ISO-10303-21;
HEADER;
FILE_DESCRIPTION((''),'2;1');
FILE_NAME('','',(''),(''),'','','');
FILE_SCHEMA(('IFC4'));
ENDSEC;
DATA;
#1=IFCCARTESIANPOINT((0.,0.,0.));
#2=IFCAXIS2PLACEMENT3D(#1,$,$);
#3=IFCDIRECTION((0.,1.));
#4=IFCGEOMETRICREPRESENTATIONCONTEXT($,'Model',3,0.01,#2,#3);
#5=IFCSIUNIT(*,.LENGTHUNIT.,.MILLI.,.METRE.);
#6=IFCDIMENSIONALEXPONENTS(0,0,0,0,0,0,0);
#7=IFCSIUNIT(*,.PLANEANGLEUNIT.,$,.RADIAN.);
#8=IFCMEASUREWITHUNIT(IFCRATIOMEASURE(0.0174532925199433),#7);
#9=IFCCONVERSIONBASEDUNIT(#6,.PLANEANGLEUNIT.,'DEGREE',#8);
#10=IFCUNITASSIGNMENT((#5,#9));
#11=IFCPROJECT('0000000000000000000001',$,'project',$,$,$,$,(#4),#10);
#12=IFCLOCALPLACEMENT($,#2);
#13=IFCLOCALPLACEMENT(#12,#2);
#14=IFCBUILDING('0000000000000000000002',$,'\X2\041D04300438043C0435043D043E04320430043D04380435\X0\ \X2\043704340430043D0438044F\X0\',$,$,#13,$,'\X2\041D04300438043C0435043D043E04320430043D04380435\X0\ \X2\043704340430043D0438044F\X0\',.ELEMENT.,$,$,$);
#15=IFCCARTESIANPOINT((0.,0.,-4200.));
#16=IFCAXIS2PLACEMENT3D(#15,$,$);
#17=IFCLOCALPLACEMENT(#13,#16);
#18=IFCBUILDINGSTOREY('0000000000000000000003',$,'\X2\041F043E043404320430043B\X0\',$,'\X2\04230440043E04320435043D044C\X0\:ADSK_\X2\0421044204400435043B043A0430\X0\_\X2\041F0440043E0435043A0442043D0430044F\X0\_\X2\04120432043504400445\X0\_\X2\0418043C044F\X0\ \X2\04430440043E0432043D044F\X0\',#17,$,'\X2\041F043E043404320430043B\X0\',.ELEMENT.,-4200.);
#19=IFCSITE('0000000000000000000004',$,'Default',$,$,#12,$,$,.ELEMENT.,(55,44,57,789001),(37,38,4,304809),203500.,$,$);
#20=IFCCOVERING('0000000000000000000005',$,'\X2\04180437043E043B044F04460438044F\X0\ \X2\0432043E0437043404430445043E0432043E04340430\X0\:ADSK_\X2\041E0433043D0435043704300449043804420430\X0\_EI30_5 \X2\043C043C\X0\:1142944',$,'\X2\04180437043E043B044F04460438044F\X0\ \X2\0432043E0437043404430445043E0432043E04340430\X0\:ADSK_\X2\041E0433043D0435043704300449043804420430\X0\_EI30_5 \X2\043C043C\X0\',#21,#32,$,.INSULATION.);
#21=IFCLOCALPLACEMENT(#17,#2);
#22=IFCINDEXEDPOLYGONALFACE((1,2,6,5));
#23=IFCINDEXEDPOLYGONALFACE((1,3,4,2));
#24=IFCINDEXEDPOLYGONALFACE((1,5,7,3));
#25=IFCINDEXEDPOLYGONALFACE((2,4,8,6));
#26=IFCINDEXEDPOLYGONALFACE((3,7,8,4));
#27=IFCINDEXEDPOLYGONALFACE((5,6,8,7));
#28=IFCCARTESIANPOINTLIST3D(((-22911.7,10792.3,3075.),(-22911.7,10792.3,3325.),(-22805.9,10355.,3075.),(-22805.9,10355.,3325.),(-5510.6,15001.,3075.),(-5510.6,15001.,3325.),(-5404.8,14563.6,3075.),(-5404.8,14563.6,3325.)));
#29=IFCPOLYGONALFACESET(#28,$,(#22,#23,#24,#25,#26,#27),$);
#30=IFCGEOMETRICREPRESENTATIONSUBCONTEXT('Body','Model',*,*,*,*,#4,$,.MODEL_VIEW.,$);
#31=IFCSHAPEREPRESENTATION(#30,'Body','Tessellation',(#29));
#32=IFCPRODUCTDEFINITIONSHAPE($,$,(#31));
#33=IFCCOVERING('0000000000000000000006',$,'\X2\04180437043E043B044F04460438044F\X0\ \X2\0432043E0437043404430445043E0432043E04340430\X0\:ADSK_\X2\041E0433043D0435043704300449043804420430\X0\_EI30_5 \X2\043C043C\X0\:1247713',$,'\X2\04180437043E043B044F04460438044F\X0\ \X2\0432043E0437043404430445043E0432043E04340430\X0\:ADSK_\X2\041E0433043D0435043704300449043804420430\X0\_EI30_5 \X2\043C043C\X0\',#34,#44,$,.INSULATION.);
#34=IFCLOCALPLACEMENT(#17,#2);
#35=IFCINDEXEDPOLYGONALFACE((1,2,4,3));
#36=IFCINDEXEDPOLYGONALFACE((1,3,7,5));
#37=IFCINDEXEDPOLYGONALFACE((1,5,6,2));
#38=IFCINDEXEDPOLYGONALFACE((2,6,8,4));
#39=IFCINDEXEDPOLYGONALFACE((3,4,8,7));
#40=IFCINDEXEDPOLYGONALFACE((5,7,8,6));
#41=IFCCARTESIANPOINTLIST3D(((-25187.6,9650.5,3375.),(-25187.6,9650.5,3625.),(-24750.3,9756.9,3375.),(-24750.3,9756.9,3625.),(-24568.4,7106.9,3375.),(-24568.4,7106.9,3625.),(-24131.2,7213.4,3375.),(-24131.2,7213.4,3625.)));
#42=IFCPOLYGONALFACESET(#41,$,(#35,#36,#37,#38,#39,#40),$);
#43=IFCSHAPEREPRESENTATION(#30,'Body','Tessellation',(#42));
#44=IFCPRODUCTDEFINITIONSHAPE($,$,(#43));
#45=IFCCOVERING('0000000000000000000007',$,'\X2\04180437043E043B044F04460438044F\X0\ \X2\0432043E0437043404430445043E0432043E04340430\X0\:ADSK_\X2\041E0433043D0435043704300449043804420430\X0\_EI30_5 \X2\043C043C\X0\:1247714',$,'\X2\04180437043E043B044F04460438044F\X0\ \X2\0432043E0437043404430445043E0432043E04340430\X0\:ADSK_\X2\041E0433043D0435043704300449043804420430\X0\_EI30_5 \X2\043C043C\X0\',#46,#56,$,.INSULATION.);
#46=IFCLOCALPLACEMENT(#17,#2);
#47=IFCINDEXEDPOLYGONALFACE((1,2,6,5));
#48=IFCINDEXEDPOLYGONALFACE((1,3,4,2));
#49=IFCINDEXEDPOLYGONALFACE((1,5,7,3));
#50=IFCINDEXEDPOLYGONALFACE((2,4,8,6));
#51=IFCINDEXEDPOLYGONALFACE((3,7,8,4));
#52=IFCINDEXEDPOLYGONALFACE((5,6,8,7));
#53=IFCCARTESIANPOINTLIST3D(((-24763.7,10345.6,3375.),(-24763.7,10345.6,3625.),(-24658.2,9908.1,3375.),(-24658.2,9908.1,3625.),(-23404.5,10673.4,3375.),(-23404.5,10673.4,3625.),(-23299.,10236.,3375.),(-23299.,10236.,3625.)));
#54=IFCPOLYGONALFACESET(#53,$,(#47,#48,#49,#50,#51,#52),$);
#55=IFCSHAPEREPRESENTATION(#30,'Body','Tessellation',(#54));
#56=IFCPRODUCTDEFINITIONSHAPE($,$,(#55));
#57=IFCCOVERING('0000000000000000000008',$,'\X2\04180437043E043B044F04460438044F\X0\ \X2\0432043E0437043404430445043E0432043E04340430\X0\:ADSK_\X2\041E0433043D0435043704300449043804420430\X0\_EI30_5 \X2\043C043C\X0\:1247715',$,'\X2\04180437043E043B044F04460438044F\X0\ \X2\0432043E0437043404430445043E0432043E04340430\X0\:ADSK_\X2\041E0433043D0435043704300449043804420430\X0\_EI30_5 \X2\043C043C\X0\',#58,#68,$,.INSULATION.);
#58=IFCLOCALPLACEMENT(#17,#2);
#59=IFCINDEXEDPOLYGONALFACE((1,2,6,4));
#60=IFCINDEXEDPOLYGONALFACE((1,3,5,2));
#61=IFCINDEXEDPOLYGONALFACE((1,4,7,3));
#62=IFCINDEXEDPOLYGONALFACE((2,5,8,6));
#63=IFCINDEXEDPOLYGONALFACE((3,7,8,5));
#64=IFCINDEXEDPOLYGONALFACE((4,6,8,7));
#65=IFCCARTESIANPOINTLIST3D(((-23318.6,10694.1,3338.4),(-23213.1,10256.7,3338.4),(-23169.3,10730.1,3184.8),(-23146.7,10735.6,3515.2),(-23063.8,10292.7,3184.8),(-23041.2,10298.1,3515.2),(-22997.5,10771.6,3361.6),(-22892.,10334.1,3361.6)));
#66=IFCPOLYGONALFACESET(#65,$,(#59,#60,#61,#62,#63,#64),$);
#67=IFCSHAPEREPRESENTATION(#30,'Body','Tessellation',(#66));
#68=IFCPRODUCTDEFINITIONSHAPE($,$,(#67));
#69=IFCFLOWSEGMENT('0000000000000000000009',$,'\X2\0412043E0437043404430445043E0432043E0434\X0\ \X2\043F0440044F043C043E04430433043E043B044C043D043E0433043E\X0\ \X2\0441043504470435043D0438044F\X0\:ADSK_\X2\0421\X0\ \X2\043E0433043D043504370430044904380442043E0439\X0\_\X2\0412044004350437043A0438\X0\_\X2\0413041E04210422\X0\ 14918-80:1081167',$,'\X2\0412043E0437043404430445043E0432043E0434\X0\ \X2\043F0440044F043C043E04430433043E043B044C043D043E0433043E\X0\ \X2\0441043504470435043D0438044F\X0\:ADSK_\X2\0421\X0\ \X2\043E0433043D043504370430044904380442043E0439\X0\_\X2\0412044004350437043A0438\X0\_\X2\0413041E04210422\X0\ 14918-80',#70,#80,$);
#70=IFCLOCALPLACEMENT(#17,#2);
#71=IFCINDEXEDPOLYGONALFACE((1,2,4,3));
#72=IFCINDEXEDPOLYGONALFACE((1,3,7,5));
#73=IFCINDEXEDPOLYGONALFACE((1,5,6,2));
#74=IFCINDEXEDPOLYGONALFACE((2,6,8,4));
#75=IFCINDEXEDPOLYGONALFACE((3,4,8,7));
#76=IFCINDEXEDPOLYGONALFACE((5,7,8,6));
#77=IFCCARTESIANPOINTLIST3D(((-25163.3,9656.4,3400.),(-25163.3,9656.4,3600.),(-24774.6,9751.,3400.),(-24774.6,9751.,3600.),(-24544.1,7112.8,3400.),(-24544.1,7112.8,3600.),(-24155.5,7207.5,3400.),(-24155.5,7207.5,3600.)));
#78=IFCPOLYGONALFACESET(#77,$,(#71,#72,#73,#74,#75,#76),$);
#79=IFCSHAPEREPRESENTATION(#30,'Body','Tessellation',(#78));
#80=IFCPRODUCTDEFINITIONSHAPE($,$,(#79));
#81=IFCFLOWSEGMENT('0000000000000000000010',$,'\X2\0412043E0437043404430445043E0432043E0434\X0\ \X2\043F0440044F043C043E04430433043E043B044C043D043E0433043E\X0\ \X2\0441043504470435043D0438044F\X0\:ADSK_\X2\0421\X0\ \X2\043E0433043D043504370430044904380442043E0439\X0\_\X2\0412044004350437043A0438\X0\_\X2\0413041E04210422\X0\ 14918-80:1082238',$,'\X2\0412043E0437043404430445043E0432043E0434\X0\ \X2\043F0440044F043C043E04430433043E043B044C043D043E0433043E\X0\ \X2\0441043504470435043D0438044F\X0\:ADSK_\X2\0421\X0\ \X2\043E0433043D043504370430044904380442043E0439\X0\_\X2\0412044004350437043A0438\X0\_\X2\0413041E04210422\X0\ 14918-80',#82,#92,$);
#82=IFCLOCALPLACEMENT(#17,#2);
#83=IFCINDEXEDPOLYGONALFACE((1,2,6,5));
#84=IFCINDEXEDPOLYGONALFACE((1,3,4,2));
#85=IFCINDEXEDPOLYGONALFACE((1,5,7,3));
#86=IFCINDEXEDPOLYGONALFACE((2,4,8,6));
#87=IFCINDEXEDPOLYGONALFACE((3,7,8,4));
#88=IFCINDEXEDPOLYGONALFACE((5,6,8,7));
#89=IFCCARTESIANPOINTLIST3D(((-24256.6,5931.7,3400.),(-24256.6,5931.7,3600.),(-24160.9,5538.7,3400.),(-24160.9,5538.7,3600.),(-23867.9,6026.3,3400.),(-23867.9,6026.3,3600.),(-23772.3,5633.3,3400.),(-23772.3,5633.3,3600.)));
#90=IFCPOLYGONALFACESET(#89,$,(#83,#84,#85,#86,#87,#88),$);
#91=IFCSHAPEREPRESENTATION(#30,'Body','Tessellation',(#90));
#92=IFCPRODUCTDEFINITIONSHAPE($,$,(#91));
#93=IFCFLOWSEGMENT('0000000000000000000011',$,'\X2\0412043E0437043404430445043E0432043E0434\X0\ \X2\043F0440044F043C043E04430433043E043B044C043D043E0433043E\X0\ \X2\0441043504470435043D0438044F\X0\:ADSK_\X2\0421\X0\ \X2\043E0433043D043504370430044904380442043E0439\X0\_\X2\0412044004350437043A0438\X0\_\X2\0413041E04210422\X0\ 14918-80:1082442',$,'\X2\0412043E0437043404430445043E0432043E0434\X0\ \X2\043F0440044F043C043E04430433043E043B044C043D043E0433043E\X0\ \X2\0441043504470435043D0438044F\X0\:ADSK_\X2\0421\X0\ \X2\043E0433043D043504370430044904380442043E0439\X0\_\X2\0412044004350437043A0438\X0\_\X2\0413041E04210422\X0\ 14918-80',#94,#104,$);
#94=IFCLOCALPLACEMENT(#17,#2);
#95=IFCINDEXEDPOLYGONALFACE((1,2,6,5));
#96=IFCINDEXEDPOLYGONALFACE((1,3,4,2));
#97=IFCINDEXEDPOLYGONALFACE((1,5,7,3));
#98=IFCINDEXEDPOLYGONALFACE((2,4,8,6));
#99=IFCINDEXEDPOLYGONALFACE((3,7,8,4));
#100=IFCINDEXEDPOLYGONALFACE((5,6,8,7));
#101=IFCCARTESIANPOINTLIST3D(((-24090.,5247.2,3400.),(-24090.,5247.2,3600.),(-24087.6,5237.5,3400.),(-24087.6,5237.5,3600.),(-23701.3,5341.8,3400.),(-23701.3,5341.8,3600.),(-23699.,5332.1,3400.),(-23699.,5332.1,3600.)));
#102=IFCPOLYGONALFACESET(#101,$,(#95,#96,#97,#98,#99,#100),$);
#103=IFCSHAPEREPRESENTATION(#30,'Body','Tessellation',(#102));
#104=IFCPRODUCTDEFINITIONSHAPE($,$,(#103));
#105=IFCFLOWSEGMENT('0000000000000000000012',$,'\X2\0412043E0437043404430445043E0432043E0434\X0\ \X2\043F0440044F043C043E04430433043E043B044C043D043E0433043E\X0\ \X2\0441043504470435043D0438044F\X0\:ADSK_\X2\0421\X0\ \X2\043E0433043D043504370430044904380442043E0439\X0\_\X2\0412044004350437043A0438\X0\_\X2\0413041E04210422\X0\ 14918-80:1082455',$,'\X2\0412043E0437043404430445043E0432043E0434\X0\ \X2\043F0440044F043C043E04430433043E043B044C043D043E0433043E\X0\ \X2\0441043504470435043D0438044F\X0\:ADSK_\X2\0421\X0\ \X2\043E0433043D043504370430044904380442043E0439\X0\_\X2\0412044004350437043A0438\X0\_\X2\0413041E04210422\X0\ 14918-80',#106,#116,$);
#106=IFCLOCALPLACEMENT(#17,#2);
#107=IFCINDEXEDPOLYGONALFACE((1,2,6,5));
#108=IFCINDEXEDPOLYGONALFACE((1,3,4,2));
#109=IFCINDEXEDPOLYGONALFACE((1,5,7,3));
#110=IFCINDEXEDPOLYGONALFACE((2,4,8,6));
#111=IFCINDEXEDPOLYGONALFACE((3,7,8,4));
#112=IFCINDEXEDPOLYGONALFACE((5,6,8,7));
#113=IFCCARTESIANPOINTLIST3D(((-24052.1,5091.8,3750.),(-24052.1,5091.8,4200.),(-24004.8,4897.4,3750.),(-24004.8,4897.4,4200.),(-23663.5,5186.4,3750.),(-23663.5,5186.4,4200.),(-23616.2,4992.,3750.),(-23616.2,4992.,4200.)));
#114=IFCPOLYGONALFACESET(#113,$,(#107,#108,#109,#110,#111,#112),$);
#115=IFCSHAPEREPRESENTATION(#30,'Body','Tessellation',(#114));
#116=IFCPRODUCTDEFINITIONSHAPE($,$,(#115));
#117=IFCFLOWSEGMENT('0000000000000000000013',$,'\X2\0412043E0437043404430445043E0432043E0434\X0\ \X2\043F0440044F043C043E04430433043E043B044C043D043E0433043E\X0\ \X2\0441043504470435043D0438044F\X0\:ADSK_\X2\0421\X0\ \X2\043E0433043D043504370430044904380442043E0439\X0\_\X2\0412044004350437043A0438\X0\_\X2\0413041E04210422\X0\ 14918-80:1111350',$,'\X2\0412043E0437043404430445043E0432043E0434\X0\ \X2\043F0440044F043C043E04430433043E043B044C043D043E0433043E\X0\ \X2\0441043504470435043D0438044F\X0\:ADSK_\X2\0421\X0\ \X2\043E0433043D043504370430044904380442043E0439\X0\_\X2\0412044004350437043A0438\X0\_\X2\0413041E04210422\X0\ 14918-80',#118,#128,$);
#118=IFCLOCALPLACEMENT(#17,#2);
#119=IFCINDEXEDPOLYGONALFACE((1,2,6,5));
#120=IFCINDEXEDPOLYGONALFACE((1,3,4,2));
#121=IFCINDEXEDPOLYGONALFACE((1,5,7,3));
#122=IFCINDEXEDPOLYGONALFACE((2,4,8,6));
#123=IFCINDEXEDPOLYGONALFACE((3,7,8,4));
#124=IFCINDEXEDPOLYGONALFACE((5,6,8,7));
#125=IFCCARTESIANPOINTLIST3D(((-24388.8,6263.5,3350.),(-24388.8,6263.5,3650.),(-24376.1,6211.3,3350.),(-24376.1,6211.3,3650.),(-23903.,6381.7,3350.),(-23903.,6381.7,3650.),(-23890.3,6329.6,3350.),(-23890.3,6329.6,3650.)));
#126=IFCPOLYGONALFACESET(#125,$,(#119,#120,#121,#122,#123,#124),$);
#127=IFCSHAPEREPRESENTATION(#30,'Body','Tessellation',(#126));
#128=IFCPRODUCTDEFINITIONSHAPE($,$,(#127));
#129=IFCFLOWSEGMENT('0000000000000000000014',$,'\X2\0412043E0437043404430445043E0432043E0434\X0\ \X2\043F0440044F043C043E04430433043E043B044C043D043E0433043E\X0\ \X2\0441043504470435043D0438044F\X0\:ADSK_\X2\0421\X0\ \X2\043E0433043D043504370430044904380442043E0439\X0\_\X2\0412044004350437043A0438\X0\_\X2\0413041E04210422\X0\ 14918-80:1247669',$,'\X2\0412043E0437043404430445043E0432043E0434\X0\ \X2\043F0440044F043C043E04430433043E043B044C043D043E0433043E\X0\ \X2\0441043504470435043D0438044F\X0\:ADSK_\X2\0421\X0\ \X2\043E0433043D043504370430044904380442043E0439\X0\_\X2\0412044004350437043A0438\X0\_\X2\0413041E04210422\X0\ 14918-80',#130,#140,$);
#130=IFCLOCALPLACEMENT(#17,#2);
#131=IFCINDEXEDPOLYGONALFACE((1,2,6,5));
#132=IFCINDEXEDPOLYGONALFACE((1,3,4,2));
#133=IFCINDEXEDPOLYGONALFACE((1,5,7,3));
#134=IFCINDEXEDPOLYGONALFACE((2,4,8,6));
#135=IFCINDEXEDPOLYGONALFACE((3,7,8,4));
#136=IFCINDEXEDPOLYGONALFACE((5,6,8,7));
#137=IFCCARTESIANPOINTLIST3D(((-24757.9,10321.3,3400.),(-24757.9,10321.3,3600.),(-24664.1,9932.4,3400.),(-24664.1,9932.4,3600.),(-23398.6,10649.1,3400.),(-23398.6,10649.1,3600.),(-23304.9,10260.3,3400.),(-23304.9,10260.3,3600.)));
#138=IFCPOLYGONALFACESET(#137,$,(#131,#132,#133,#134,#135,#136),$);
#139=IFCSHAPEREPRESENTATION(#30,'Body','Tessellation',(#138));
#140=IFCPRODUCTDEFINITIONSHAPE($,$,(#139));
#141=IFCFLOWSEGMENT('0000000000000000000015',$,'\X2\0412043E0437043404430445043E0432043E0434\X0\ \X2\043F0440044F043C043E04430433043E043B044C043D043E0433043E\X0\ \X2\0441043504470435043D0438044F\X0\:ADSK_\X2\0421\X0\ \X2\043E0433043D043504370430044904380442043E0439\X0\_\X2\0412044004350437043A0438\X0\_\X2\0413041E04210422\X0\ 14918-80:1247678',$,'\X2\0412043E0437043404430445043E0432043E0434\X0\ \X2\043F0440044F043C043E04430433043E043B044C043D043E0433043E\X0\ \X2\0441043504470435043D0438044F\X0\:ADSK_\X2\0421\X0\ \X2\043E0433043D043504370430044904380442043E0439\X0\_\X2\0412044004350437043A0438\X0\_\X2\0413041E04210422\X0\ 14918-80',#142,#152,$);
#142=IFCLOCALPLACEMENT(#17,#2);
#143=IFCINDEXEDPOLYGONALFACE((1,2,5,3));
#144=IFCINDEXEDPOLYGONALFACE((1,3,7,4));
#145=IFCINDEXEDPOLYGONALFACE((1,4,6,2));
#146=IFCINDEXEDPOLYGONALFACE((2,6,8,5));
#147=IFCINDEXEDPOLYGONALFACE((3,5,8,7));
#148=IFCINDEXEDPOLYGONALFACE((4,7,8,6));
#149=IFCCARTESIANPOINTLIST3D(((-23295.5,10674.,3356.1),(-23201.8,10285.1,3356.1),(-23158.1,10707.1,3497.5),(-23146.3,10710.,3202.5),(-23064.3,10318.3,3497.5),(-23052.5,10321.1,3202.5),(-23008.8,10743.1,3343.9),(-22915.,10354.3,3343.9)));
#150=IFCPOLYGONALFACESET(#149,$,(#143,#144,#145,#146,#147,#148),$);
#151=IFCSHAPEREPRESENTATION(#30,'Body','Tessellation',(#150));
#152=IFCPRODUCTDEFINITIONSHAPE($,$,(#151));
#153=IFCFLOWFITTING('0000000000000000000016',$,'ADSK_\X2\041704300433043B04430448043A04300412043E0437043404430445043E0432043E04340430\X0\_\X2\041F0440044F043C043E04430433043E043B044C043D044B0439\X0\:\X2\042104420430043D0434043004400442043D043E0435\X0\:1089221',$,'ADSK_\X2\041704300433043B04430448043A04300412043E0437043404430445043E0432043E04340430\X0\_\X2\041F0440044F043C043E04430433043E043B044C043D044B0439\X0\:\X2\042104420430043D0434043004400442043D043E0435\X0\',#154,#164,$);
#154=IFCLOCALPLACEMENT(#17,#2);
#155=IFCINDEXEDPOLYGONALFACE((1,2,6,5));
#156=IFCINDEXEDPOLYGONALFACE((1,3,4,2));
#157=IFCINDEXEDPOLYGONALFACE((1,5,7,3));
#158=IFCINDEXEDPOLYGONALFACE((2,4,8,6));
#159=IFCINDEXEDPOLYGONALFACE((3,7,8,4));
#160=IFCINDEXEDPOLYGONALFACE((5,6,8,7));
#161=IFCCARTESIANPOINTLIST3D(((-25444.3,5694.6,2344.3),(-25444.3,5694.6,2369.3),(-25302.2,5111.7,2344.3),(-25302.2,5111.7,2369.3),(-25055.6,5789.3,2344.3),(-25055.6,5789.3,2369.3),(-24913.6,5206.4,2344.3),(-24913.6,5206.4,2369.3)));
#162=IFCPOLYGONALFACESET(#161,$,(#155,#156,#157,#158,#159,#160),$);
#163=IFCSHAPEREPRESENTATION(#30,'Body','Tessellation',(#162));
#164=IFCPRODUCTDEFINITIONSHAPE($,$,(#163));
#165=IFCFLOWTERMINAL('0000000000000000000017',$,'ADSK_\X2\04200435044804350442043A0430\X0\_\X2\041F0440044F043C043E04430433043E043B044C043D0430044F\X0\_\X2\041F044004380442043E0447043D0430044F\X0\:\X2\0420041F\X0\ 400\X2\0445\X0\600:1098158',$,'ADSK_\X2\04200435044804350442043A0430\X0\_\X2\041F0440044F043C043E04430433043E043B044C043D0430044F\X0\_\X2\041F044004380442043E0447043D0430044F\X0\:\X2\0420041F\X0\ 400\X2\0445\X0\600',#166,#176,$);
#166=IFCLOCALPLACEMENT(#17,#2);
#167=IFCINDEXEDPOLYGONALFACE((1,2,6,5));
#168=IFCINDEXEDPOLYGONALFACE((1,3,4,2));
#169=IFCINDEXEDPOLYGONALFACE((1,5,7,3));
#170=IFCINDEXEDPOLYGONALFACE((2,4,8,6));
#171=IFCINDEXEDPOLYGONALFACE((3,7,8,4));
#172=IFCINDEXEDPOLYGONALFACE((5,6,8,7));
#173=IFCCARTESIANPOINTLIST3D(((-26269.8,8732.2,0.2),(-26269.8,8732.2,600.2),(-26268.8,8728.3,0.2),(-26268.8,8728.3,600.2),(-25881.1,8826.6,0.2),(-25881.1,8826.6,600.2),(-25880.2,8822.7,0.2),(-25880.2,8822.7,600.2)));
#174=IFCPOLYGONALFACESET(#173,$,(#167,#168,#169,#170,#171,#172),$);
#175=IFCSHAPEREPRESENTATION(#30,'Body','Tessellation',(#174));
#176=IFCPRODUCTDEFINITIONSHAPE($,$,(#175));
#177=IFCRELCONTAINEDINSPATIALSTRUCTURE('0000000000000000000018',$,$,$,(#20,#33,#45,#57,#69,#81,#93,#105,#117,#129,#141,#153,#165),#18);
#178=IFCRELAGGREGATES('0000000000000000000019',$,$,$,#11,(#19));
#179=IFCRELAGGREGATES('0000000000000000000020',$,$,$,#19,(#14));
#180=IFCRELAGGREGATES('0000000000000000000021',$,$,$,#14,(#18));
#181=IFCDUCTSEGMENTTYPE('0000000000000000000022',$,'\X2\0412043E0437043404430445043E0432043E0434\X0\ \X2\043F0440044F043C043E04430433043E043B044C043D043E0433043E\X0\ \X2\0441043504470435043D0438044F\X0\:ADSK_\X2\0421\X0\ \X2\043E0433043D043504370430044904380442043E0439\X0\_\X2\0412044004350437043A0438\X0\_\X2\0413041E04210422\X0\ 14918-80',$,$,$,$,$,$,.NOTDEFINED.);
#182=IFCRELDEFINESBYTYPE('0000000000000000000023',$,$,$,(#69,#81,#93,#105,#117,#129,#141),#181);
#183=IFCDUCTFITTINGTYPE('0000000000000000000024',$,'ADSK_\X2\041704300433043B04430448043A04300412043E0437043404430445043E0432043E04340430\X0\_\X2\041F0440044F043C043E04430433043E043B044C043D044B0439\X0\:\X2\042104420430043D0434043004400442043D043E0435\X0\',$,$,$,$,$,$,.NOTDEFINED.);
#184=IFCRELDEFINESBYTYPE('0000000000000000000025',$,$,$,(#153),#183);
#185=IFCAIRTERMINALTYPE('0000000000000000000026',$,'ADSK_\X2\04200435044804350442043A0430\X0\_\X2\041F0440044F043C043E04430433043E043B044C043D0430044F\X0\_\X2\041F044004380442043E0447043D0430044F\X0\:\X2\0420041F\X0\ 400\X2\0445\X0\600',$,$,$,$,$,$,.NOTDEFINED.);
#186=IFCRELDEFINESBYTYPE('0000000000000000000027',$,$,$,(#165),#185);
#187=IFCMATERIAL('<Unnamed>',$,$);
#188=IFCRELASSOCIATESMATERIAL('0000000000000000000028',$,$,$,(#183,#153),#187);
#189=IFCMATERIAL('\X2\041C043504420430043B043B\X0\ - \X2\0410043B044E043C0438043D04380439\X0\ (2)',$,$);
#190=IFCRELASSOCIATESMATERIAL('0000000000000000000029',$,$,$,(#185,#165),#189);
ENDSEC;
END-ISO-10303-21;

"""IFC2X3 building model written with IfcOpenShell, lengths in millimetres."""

from ifc_helpers import new_model, entity, si_unit, converted_unit, direction, frame, frame_2d, origin, origin_2d_with_axis, place, context, subcontext, project, spatial, rectangle, extrude, source, transform, mapped, material, type_object, type_shapes, element, save


model = new_model("IFC2X3")

# Units and contexts
model_context = context("Model", 3, precision=0.01, world=origin(), true_north=direction((0.0, 1.0)))
body_context = subcontext(model_context, "Body", "Model", "MODEL_VIEW")
ifc_project = project(units=[si_unit("LENGTHUNIT", "METRE", prefix="MILLI"), converted_unit("PLANEANGLEUNIT", "DEGREE", entity("IfcRatioMeasure", 0.0174532925199433), si_unit("PLANEANGLEUNIT", "RADIAN"), dimensions=[0, 0, 0, 0, 0, 0, 0])], contexts=[model_context])

# Site, building, storey
site_placement = place(None, frame((0.0, 0.0, 0.0)))
site = spatial("IfcSite", under=ifc_project, at=site_placement, Name="Default", CompositionType="ELEMENT", RefLatitude=(55, 44, 57, 789001), RefLongitude=(37, 38, 4, 304809), RefElevation=203500.0)
building_placement = place(site_placement, origin())
building = spatial("IfcBuilding", under=site, at=building_placement, Name="Наименование здания", LongName="Наименование здания", CompositionType="ELEMENT")
storey_placement = place(building_placement, frame((0.0, 0.0, -4200.0)))
storey = spatial("IfcBuildingStorey", under=building, at=storey_placement, Name="Подвал", ObjectType="Уровень:ADSK_Стрелка_Проектная_Вверх_Имя уровня", LongName="Подвал", CompositionType="ELEMENT", Elevation=-4200.0)

# Coverings
covering_1_placement = place(storey_placement, frame((-22911.7, 10355.0, 3075.0)))
element("IfcCovering", 1, at=covering_1_placement, inside=storey, Name="Изоляция воздуховода:ADSK_Огнезащита_EI30_5 мм:1142944", ObjectType="Изоляция воздуховода:ADSK_Огнезащита_EI30_5 мм", PredefinedType="INSULATION", context=body_context, shape_type="SweptSolid", body=[
    extrude(rectangle(XDim=17902.8, YDim=450.0, at=frame_2d((0.0, 0.0), x_axis=(1.0, 0.0))), frame((8753.4, 2323.0, 0.0), z_axis=(0.0, 0.0, 1.0), x_axis=(-0.971976, -0.235081, 0.0)), (0.0, 0.0, 1.0), 250.0),
])
covering_2_placement = place(storey_placement, frame((-25187.6, 7106.9, 3375.0)))
element("IfcCovering", 2, at=covering_2_placement, inside=storey, Name="Изоляция воздуховода:ADSK_Огнезащита_EI30_5 мм:1247713", ObjectType="Изоляция воздуховода:ADSK_Огнезащита_EI30_5 мм", PredefinedType="INSULATION", context=body_context, shape_type="SweptSolid", body=[
    extrude(rectangle(XDim=2617.9, YDim=450.0, at=frame_2d((0.0, 0.0), x_axis=(1.0, 0.0))), frame((528.2, 1325.0, 0.0), z_axis=(0.0, 0.0, 1.0), x_axis=(-0.236518, 0.971627, 0.0)), (0.0, 0.0, 1.0), 250.0),
])
covering_3_placement = place(storey_placement, frame((-24763.7, 9908.1, 3375.0)))
element("IfcCovering", 3, at=covering_3_placement, inside=storey, Name="Изоляция воздуховода:ADSK_Огнезащита_EI30_5 мм:1247714", ObjectType="Изоляция воздуховода:ADSK_Огнезащита_EI30_5 мм", PredefinedType="INSULATION", context=body_context, shape_type="SweptSolid", body=[
    extrude(rectangle(XDim=1398.2, YDim=450.0, at=frame_2d((0.0, 0.0), x_axis=(1.0, 0.0))), frame((732.4, 382.6, 0.0), z_axis=(0.0, 0.0, 1.0), x_axis=(-0.972125, -0.234462, 0.0)), (0.0, 0.0, 1.0), 250.0),
])
covering_4_placement = place(storey_placement, frame((-23318.6, 10256.7, 3184.8)))
element("IfcCovering", 4, at=covering_4_placement, inside=storey, Name="Изоляция воздуховода:ADSK_Огнезащита_EI30_5 мм:1247715", ObjectType="Изоляция воздуховода:ADSK_Огнезащита_EI30_5 мм", PredefinedType="INSULATION", context=body_context, shape_type="SweptSolid", body=[
    extrude(rectangle(XDim=250.0, YDim=217.2, at=frame_2d((0.0, 0.0), x_axis=(0.0, 1.0))), frame((266.1, 38.7, 165.2), z_axis=(-0.234462, 0.972125, 0.0), x_axis=(-0.687396, -0.16579, 0.707107)), (0.0, 0.0, 1.0), 450.0),
])

# Flow segments
duct_segment_type_1 = type_object("IfcDuctSegmentType", Name="Воздуховод прямоугольного сечения:ADSK_С огнезащитой_Врезки_ГОСТ 14918-80", PredefinedType="NOTDEFINED")
flow_segment_1_placement = place(storey_placement, frame((-25163.3, 7112.8, 3400.0)))
element("IfcFlowSegment", 5, at=flow_segment_1_placement, inside=storey, type_object=duct_segment_type_1, Name="Воздуховод прямоугольного сечения:ADSK_С огнезащитой_Врезки_ГОСТ 14918-80:1081167", ObjectType="Воздуховод прямоугольного сечения:ADSK_С огнезащитой_Врезки_ГОСТ 14918-80", context=body_context, shape_type="SweptSolid", body=[
    extrude(rectangle(XDim=2617.9, YDim=400.0, at=frame_2d((0.0, 0.0), x_axis=(1.0, 0.0))), frame((503.9, 1319.1, 0.0), z_axis=(0.0, 0.0, 1.0), x_axis=(-0.236518, 0.971627, 0.0)), (0.0, 0.0, 1.0), 200.0),
])
flow_segment_2_placement = place(storey_placement, frame((-24256.6, 5538.7, 3400.0)))
element("IfcFlowSegment", 6, at=flow_segment_2_placement, inside=storey, type_object=duct_segment_type_1, Name="Воздуховод прямоугольного сечения:ADSK_С огнезащитой_Врезки_ГОСТ 14918-80:1082238", ObjectType="Воздуховод прямоугольного сечения:ADSK_С огнезащитой_Врезки_ГОСТ 14918-80", context=body_context, shape_type="SweptSolid", body=[
    extrude(rectangle(XDim=404.4, YDim=400.0, at=frame_2d((0.0, 0.0), x_axis=(1.0, 0.0))), frame((242.2, 243.8, 0.0), z_axis=(0.0, 0.0, 1.0), x_axis=(-0.236517, 0.971627, 0.0)), (0.0, 0.0, 1.0), 200.0),
])
flow_segment_3_placement = place(storey_placement, frame((-24090.0, 5237.5, 3400.0)))
element("IfcFlowSegment", 7, at=flow_segment_3_placement, inside=storey, type_object=duct_segment_type_1, Name="Воздуховод прямоугольного сечения:ADSK_С огнезащитой_Врезки_ГОСТ 14918-80:1082442", ObjectType="Воздуховод прямоугольного сечения:ADSK_С огнезащитой_Врезки_ГОСТ 14918-80", context=body_context, shape_type="SweptSolid", body=[
    extrude(rectangle(XDim=10.0, YDim=400.0, at=frame_2d((0.0, 0.0), x_axis=(1.0, 0.0))), frame((195.5, 52.2, 0.0), z_axis=(0.0, 0.0, 1.0), x_axis=(0.236517, -0.971627, 0.0)), (0.0, 0.0, 1.0), 200.0),
])
flow_segment_4_placement = place(storey_placement, frame((-24052.1, 4897.4, 3750.0)))
element("IfcFlowSegment", 8, at=flow_segment_4_placement, inside=storey, type_object=duct_segment_type_1, Name="Воздуховод прямоугольного сечения:ADSK_С огнезащитой_Врезки_ГОСТ 14918-80:1082455", ObjectType="Воздуховод прямоугольного сечения:ADSK_С огнезащитой_Врезки_ГОСТ 14918-80", context=body_context, shape_type="SweptSolid", body=[
    extrude(rectangle(XDim=200.0, YDim=400.0, at=origin_2d_with_axis()), frame((218.0, 144.5, 0.0), z_axis=(0.0, 0.0, 1.0), x_axis=(-0.236517, 0.971627, 0.0)), (0.0, 0.0, 1.0), 450.0),
])
flow_segment_5_placement = place(storey_placement, frame((-24388.8, 6211.3, 3350.0)))
element("IfcFlowSegment", 9, at=flow_segment_5_placement, inside=storey, type_object=duct_segment_type_1, Name="Воздуховод прямоугольного сечения:ADSK_С огнезащитой_Врезки_ГОСТ 14918-80:1111350", ObjectType="Воздуховод прямоугольного сечения:ADSK_С огнезащитой_Врезки_ГОСТ 14918-80", context=body_context, shape_type="SweptSolid", body=[
    extrude(rectangle(XDim=53.7, YDim=500.0, at=origin_2d_with_axis()), frame((249.3, 85.2, 0.0), z_axis=(0.0, 0.0, 1.0), x_axis=(0.236517, -0.971627, 0.0)), (0.0, 0.0, 1.0), 300.0),
])
flow_segment_6_placement = place(storey_placement, frame((-24757.9, 9932.4, 3400.0)))
element("IfcFlowSegment", 10, at=flow_segment_6_placement, inside=storey, type_object=duct_segment_type_1, Name="Воздуховод прямоугольного сечения:ADSK_С огнезащитой_Врезки_ГОСТ 14918-80:1247669", ObjectType="Воздуховод прямоугольного сечения:ADSK_С огнезащитой_Врезки_ГОСТ 14918-80", context=body_context, shape_type="SweptSolid", body=[
    extrude(rectangle(XDim=1398.2, YDim=400.0, at=frame_2d((0.0, 0.0), x_axis=(1.0, 0.0))), frame((726.5, 358.3, 0.0), z_axis=(0.0, 0.0, 1.0), x_axis=(-0.972125, -0.234462, 0.0)), (0.0, 0.0, 1.0), 200.0),
])
flow_segment_7_placement = place(storey_placement, frame((-23295.5, 10285.1, 3202.5)))
element("IfcFlowSegment", 11, at=flow_segment_7_placement, inside=storey, type_object=duct_segment_type_1, Name="Воздуховод прямоугольного сечения:ADSK_С огнезащитой_Врезки_ГОСТ 14918-80:1247678", ObjectType="Воздуховод прямоугольного сечения:ADSK_С огнезащитой_Врезки_ГОСТ 14918-80", context=body_context, shape_type="SweptSolid", body=[
    extrude(rectangle(XDim=200.0, YDim=217.2, at=frame_2d((0.0, 0.0), x_axis=(0.0, 1.0))), frame((237.2, 34.6, 147.5), z_axis=(-0.234462, 0.972125, 0.0), x_axis=(-0.687396, -0.16579, 0.707107)), (0.0, 0.0, 1.0), 400.0),
])

# Flow fitting
ifc_material_1 = material(Name="<Unnamed>")
duct_fitting_type_1 = type_object("IfcDuctFittingType", Name="ADSK_ЗаглушкаВоздуховода_Прямоугольный:Стандартное", PredefinedType="NOTDEFINED", material=ifc_material_1)
shared_shape_1 = source(origin(), body_context, "Body", "SweptSolid", [
    extrude(rectangle(XDim=25.0, YDim=400.0, at=frame_2d((0.0, 0.0), x_axis=(1.0, 0.0))), frame((12.5, 0.0, -300.0)), (0.0, 0.0, 1.0), 600.0),
])
type_shapes(duct_fitting_type_1, [shared_shape_1])
flow_fitting_1_placement = place(storey_placement, frame((-25178.9, 5450.5, 2344.3), z_axis=(0.236821, -0.971553, 0.0), x_axis=(0.0, 0.0, 1.0)))
element("IfcFlowFitting", 12, at=flow_fitting_1_placement, inside=storey, type_object=duct_fitting_type_1, material=ifc_material_1, Name="ADSK_ЗаглушкаВоздуховода_Прямоугольный:Стандартное:1089221", ObjectType="ADSK_ЗаглушкаВоздуховода_Прямоугольный:Стандартное", context=body_context, shape_type="MappedRepresentation", body=[
    mapped(shared_shape_1, transform((0.0, 0.0, 0.0), scale=1.0)),
])

# Flow terminal
ifc_material_2 = material(Name="Металл - Алюминий (2)")
air_terminal_type = type_object("IfcAirTerminalType", Name="ADSK_Решетка_Прямоугольная_Приточная:РП 400х600", PredefinedType="NOTDEFINED", material=ifc_material_2)
shared_shape_2 = source(origin(), body_context, "Body", "SweptSolid", [
    extrude(rectangle(XDim=4.0, YDim=400.0, at=origin_2d_with_axis()), frame((0.0, -2.0, -300.0), z_axis=(0.0, 0.0, 1.0), x_axis=(0.0, 1.0, 0.0)), (0.0, 0.0, 1.0), 600.0),
])
type_shapes(air_terminal_type, [shared_shape_2])
flow_terminal_placement = place(storey_placement, frame((-26074.5, 8775.5, 300.2), z_axis=(0.0, 0.0, 1.0), x_axis=(-0.971714, -0.23616, 0.0)))
element("IfcFlowTerminal", 13, at=flow_terminal_placement, inside=storey, type_object=air_terminal_type, material=ifc_material_2, Name="ADSK_Решетка_Прямоугольная_Приточная:РП 400х600:1098158", ObjectType="ADSK_Решетка_Прямоугольная_Приточная:РП 400х600", context=body_context, shape_type="MappedRepresentation", body=[
    mapped(shared_shape_2, transform((0.0, 0.0, 0.0), scale=1.0)),
])

save(model, "model.ifc")
